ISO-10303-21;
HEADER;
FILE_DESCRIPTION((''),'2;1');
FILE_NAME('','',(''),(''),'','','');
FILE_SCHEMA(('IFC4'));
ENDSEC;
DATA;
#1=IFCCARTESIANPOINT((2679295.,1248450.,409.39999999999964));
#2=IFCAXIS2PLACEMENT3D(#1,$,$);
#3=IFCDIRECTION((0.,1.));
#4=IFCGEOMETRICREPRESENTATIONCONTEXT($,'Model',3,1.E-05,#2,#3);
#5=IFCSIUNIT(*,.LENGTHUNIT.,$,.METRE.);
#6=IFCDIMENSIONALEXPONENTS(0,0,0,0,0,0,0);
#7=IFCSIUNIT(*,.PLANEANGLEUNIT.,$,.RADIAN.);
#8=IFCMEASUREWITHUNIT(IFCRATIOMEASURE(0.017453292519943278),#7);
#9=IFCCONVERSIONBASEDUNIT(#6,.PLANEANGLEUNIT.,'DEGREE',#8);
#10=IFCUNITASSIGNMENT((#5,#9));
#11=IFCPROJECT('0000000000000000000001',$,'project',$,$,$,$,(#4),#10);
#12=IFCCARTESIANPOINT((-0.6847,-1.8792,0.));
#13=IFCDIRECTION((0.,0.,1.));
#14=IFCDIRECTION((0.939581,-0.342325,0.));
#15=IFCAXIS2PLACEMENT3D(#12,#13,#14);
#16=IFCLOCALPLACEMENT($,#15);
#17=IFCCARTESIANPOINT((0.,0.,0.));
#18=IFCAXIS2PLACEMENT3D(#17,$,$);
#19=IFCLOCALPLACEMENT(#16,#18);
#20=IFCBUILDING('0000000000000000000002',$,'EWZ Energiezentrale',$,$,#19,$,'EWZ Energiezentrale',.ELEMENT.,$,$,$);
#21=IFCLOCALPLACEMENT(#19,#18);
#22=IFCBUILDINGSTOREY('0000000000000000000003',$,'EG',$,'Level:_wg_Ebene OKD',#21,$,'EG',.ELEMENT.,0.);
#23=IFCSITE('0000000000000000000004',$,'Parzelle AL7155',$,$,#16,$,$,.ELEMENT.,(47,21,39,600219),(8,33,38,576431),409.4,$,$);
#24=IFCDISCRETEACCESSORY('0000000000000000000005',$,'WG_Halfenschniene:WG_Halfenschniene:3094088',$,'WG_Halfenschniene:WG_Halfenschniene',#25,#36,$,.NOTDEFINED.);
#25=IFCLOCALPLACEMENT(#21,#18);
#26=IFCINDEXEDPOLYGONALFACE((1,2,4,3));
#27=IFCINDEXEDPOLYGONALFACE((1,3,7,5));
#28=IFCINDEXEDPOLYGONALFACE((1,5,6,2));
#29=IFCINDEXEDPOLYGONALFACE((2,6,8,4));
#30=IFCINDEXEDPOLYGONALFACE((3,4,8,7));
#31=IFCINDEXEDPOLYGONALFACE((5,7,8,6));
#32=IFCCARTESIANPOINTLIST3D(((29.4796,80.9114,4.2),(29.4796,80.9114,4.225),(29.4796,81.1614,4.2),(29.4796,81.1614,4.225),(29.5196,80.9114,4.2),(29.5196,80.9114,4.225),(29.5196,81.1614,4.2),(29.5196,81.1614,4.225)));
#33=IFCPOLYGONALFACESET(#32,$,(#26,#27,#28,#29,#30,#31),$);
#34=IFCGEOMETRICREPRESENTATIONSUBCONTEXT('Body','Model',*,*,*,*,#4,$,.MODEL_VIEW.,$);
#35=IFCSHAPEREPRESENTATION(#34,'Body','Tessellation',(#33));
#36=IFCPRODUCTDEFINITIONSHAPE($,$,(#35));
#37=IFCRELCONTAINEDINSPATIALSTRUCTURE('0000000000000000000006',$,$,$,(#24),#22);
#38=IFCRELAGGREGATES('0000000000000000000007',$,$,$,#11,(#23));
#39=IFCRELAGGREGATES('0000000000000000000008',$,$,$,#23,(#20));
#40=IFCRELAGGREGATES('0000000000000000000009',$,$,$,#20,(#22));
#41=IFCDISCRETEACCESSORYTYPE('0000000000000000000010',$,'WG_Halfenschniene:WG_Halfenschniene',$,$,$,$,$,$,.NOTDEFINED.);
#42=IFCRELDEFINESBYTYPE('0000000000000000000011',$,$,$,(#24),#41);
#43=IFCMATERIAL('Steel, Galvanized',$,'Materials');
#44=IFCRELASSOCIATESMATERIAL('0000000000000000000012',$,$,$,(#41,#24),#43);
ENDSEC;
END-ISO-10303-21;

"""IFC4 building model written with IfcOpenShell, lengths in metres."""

from ifc_helpers import new_model, entity, si_unit, converted_unit, direction, frame, origin, place, context, subcontext, project, spatial, indexed_curve, outline, extrude, source, transform, mapped, material, type_object, element, save


model = new_model("IFC4")

# Units and contexts
model_context = context("Model", 3, precision=1e-05, world=frame((2679295.0, 1248450.0, 409.39999999999964)), true_north=direction((0.0, 1.0)))
body_context = subcontext(model_context, "Body", "Model", "MODEL_VIEW")
ifc_project = project(units=[si_unit("LENGTHUNIT", "METRE"), converted_unit("PLANEANGLEUNIT", "DEGREE", entity("IfcRatioMeasure", 0.017453292519943278), si_unit("PLANEANGLEUNIT", "RADIAN"), dimensions=[0, 0, 0, 0, 0, 0, 0])], contexts=[model_context])

# Site, building, storey
site_placement = place(None, frame((-0.6847, -1.8792, 0.0), z_axis=(0.0, 0.0, 1.0), x_axis=(0.939581, -0.342325, 0.0)))
site = spatial("IfcSite", under=ifc_project, at=site_placement, Name="Parzelle AL7155", CompositionType="ELEMENT", RefLatitude=(47, 21, 39, 600219), RefLongitude=(8, 33, 38, 576431), RefElevation=409.4)
building_placement = place(site_placement, origin())
building = spatial("IfcBuilding", under=site, at=building_placement, Name="EWZ Energiezentrale", LongName="EWZ Energiezentrale", CompositionType="ELEMENT")
storey_placement = place(building_placement, origin())
storey = spatial("IfcBuildingStorey", under=building, at=storey_placement, Name="EG", ObjectType="Level:_wg_Ebene OKD", LongName="EG", CompositionType="ELEMENT", Elevation=0.0)

# Discrete accessory
ifc_material = material(Name="Steel, Galvanized", Category="Materials")
discrete_accessory_type = type_object("IfcDiscreteAccessoryType", Name="WG_Halfenschniene:WG_Halfenschniene", PredefinedType="NOTDEFINED", material=ifc_material)
shared_shape = source(origin(), body_context, "Body", "SweptSolid", [
    extrude(outline(indexed_curve([(-0.125, -0.02), (0.125, -0.02), (0.125, 0.02), (-0.125, 0.02), (-0.125, -0.02)], self_intersect=False)), frame((0.125, 0.0, -0.0125)), (0.0, 0.0, 1.0), 0.025),
])
for number, where, z_axis, x_axis, name in (
    (1, (29.4996, 80.9114, 4.2125), (0.0, 0.0, -1.0), (0.0, 1.0, 0.0), "WG_Halfenschniene:WG_Halfenschniene:3094088"),
):
    element("IfcDiscreteAccessory", number, at=place(storey_placement, frame(where, z_axis=z_axis, x_axis=x_axis)), inside=storey, type_object=discrete_accessory_type, material=ifc_material, Name=name, ObjectType="WG_Halfenschniene:WG_Halfenschniene", PredefinedType="NOTDEFINED", context=body_context, shape_type="MappedRepresentation", body=[
        mapped(shared_shape, transform((0.0, 0.0, 0.0), scale=1.0)),
    ])

save(model, "model.ifc")
